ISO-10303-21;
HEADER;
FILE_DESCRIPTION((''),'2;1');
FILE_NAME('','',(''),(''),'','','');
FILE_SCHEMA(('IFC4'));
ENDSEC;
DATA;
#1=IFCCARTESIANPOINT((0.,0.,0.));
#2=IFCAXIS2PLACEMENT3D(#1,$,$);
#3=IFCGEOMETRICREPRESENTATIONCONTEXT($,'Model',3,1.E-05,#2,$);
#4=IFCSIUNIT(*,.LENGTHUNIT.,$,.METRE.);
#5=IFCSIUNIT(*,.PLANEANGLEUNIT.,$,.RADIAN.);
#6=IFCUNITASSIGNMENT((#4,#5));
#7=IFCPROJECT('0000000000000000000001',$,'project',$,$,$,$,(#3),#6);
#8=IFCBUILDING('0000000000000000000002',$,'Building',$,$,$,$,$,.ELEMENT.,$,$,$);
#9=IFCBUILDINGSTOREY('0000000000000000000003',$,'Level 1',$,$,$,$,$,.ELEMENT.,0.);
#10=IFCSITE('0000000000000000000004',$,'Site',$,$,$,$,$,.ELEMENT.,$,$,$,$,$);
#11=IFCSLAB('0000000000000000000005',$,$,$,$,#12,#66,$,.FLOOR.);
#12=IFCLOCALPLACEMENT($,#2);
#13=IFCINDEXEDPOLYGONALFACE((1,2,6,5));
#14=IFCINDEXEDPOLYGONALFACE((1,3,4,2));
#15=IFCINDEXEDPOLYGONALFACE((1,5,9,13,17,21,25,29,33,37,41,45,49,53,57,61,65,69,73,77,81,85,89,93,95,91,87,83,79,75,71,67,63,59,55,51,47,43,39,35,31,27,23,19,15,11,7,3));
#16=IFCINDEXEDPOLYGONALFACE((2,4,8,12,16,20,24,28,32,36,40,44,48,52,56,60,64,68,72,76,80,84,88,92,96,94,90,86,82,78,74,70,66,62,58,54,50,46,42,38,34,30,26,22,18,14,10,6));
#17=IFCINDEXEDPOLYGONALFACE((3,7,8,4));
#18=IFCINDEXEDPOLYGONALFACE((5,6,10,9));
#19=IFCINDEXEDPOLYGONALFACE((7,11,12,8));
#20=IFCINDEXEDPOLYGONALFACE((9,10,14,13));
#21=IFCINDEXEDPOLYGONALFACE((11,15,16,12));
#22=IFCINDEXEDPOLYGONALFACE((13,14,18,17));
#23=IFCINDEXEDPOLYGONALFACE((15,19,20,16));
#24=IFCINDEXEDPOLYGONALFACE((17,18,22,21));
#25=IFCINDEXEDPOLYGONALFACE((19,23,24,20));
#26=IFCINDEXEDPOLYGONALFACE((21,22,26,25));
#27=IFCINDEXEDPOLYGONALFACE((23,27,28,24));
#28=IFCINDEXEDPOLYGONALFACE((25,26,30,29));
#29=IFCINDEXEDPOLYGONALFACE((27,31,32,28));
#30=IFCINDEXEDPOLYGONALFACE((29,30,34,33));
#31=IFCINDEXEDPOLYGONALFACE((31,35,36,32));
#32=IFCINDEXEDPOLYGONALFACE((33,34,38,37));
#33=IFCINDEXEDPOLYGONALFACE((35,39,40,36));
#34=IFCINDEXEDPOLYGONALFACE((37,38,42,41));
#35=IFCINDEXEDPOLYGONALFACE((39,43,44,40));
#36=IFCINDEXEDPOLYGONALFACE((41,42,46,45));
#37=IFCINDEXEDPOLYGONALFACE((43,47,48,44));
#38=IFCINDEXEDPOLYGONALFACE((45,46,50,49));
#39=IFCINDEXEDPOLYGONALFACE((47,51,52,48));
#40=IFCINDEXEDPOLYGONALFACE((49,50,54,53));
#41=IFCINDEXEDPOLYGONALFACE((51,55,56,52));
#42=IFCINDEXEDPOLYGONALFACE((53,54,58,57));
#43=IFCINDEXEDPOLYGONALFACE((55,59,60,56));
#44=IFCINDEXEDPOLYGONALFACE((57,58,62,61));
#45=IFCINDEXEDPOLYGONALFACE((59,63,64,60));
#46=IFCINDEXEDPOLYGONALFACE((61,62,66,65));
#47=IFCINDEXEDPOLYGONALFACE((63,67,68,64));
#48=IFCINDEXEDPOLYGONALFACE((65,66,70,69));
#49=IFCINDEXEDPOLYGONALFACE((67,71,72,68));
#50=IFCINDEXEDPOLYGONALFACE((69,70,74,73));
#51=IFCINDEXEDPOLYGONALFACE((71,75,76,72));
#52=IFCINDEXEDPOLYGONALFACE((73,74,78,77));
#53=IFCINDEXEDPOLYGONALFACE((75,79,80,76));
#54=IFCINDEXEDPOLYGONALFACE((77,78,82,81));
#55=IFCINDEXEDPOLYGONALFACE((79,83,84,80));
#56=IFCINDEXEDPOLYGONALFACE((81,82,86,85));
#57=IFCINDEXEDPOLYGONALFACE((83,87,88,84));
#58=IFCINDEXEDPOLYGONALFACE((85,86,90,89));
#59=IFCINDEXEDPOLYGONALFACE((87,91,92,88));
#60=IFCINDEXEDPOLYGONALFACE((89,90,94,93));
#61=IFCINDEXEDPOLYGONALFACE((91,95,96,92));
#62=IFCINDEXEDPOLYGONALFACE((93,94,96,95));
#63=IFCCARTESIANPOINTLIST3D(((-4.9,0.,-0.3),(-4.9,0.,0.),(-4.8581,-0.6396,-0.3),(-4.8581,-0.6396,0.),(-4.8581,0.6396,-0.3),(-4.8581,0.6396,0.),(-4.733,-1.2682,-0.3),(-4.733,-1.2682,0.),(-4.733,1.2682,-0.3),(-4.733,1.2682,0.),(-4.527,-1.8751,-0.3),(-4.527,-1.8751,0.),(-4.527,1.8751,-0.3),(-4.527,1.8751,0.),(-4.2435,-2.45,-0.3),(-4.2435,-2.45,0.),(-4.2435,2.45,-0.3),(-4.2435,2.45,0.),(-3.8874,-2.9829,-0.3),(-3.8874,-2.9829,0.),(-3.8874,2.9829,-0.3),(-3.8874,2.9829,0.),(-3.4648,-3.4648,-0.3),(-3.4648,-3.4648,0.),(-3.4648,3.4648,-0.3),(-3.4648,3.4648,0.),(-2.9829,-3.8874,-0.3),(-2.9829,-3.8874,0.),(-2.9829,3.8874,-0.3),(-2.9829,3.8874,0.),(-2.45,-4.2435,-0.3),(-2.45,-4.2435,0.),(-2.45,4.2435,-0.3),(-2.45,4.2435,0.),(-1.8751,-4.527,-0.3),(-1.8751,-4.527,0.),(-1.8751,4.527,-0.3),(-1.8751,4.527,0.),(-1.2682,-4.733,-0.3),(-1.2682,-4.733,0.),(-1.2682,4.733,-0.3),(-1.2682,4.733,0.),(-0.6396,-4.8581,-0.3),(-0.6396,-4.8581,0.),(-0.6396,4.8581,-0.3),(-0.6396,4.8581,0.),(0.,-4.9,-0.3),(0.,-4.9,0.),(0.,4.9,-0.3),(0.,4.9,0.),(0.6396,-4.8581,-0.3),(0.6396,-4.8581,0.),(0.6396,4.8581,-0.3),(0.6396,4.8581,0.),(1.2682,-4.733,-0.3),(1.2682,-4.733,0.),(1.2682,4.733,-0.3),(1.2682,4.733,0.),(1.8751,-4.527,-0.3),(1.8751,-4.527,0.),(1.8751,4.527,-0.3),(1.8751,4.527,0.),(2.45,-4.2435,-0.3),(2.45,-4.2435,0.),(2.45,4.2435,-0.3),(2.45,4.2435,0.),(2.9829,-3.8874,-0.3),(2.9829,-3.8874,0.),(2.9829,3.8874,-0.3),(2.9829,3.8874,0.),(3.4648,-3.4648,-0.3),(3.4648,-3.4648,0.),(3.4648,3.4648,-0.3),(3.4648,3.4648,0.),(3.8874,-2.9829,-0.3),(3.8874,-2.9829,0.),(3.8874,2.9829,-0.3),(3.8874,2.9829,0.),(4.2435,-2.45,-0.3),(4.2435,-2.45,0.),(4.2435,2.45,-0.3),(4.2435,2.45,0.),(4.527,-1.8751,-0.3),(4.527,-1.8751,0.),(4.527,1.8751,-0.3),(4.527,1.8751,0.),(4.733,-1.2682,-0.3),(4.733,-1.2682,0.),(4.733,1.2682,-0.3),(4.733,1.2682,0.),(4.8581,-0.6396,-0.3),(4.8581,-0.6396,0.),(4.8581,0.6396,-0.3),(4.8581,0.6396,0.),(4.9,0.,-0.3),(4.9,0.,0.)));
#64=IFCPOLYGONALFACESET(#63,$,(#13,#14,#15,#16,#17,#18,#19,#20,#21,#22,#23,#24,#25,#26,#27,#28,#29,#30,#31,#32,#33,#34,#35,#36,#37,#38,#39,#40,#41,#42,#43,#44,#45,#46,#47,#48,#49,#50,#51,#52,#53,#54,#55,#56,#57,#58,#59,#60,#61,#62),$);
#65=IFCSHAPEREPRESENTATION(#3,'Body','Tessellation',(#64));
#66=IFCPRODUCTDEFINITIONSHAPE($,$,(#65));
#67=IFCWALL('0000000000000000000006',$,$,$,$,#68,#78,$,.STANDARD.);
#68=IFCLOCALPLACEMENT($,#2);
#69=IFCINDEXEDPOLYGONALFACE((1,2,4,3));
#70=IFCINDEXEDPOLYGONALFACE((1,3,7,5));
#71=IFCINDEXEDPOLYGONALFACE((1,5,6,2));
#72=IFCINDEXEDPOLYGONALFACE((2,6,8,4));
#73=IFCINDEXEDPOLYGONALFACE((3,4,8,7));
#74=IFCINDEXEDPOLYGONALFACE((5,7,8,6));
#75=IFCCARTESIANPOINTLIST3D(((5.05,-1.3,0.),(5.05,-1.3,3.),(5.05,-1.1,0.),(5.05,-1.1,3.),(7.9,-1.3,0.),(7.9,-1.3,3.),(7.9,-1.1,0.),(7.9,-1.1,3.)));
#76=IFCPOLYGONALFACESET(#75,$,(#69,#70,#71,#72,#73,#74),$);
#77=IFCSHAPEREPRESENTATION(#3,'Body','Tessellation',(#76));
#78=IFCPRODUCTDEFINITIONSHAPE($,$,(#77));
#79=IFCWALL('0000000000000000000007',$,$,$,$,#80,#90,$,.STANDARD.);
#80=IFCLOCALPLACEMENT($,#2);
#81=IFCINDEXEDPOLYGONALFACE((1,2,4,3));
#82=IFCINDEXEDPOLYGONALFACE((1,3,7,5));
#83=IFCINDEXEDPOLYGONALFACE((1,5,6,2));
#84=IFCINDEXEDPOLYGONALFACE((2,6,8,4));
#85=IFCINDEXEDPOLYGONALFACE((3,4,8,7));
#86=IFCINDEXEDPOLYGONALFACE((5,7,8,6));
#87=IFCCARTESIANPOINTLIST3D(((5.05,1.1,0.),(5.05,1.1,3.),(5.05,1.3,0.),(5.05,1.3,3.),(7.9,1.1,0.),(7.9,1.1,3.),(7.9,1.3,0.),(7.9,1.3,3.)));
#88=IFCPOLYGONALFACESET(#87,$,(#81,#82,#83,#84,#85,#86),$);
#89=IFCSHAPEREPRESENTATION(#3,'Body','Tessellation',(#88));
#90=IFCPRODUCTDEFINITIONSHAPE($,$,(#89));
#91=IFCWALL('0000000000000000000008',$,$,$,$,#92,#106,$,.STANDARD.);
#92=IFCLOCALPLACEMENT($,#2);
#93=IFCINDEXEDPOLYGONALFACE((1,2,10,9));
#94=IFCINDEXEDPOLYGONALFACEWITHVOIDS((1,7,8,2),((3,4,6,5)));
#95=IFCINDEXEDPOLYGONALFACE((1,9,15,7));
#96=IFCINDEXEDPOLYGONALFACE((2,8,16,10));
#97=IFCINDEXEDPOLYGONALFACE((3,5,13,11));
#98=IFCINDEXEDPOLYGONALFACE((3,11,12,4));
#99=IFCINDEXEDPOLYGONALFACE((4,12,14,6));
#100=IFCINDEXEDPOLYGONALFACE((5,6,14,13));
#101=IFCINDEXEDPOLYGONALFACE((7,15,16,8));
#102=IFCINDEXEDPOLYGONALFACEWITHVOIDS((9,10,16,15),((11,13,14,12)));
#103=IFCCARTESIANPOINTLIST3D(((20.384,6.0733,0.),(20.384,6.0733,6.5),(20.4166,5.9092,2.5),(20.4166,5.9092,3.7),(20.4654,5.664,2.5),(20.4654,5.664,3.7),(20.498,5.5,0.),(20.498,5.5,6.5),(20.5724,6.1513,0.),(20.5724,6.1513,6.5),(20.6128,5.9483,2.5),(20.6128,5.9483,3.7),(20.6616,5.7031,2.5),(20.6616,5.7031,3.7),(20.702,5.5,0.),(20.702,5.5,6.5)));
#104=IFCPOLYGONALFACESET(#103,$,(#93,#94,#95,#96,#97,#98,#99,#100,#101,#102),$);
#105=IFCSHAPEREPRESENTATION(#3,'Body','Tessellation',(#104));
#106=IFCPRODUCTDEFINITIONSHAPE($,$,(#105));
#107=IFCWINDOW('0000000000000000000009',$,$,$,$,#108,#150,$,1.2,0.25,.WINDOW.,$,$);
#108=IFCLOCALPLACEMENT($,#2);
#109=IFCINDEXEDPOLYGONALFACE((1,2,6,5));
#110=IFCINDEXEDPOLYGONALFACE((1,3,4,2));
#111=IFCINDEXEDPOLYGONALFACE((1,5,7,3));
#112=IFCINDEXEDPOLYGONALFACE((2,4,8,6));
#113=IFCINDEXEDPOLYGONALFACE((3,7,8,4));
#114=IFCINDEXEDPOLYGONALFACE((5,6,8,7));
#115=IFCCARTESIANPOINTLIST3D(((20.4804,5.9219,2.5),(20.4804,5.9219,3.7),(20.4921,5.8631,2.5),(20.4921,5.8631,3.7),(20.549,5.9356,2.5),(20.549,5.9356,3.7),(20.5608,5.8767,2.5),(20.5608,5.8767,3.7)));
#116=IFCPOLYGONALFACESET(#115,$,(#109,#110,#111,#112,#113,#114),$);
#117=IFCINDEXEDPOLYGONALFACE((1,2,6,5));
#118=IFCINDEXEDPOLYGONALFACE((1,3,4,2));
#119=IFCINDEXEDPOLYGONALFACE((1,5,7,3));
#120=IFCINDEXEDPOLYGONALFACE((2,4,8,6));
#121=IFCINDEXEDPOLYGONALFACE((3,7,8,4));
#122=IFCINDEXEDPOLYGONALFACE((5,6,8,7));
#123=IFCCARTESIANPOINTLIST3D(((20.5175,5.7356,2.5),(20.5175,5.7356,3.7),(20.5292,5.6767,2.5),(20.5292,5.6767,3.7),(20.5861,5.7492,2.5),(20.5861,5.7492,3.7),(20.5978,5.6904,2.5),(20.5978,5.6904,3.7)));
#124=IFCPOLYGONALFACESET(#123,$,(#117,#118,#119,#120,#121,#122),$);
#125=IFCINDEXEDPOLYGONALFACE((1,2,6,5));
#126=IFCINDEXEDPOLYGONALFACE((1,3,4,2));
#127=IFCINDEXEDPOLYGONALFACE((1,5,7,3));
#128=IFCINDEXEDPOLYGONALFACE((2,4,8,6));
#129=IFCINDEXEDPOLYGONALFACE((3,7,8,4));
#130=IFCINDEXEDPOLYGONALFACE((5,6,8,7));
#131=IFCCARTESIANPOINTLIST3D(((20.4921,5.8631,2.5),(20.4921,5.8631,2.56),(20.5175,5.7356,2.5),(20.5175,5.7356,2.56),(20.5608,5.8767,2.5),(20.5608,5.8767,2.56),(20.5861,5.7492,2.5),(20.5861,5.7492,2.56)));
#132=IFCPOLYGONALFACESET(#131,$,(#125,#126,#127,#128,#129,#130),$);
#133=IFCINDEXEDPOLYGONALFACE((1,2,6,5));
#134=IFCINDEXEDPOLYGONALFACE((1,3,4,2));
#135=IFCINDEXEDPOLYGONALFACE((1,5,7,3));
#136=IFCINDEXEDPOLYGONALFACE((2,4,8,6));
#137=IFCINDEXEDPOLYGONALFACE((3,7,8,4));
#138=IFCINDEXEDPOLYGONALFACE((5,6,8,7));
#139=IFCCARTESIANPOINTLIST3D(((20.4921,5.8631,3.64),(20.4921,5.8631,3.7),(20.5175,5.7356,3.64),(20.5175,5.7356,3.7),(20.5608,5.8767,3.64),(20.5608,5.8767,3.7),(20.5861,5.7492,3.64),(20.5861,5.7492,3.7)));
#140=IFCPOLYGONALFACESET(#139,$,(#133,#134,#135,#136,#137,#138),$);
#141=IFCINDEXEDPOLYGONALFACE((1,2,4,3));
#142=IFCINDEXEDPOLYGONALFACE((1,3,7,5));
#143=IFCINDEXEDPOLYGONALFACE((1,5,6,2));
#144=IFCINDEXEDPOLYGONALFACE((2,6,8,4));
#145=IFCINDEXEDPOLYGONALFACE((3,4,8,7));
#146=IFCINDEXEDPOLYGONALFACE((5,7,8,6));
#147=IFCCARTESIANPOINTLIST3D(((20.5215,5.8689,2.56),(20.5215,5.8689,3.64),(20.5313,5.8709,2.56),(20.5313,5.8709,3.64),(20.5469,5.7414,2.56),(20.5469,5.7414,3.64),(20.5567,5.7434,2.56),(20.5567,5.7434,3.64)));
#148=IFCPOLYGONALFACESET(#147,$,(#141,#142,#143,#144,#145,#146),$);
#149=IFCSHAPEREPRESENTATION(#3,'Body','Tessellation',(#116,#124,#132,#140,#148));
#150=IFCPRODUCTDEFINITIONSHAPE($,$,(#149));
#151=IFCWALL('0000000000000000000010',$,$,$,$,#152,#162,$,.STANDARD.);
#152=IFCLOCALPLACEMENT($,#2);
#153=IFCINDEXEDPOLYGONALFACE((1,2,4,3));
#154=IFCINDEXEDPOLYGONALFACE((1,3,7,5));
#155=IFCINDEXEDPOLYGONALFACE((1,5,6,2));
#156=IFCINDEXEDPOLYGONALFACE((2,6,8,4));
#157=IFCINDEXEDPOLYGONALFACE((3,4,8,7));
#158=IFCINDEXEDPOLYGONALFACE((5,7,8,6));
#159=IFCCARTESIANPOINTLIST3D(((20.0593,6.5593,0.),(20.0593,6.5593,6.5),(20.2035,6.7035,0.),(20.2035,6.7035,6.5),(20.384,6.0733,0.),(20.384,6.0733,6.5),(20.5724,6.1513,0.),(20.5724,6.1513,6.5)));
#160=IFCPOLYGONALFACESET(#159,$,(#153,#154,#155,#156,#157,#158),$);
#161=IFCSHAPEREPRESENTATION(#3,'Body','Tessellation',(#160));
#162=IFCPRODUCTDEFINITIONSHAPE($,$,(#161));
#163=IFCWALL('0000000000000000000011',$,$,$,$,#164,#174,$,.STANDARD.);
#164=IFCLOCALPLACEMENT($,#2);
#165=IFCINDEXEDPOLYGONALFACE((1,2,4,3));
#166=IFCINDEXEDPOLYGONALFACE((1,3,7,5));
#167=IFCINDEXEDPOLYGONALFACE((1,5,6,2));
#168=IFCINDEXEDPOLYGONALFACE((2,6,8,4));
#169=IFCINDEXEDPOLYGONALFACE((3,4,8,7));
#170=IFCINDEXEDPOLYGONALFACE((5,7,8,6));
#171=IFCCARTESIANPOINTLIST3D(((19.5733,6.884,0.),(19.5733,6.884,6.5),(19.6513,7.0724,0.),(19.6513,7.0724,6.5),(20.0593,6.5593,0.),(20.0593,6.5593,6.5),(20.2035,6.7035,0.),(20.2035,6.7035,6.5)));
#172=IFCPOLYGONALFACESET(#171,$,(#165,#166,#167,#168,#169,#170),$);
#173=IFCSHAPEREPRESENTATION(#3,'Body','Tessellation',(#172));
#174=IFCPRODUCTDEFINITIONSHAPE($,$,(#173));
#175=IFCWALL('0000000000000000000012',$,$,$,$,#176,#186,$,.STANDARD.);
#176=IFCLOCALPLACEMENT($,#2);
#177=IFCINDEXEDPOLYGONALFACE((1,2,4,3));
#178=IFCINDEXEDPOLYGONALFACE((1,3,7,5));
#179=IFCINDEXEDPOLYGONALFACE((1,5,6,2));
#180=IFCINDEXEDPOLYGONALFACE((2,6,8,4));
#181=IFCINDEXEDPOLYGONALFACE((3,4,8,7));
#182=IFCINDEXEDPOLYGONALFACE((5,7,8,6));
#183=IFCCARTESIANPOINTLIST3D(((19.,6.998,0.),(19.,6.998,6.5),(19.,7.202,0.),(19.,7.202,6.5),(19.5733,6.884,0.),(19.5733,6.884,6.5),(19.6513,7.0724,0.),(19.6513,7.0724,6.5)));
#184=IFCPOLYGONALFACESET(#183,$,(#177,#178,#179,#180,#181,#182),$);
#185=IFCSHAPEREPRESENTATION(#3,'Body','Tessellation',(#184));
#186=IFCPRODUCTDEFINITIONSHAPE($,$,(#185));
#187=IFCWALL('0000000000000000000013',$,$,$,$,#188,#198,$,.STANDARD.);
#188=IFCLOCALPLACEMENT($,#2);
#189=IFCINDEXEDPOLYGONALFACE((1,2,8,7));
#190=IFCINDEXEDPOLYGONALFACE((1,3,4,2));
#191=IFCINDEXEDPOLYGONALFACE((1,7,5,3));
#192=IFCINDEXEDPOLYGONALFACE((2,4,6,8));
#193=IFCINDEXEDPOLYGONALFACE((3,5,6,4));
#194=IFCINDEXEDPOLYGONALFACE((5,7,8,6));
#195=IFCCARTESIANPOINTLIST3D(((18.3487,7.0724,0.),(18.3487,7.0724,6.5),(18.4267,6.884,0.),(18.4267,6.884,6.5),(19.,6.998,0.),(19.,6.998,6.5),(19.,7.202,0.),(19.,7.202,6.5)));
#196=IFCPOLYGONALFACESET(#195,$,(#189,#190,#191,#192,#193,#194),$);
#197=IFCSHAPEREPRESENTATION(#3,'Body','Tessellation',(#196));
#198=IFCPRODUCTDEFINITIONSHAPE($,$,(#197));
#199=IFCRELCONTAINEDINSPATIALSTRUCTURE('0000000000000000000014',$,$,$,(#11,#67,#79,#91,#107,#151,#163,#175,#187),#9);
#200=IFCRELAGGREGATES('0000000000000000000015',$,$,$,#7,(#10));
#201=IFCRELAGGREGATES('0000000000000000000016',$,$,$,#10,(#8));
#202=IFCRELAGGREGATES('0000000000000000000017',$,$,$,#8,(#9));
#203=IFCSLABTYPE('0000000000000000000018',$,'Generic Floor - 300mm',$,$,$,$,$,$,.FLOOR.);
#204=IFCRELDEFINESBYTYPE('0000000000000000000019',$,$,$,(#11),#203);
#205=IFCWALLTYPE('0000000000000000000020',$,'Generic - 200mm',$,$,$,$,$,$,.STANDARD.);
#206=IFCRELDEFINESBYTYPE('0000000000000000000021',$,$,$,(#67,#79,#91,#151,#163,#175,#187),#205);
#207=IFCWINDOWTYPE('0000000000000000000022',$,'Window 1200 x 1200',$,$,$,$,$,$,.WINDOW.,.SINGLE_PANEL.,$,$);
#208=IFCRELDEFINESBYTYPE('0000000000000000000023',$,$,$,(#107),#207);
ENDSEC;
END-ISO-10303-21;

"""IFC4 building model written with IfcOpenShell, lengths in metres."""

from ifc_helpers import new_model, si_unit, frame, frame_2d, origin, origin_with_axes, origin_2d, place, context, project, spatial, polyline, rectangle, outline, extrude, type_object, element, fill, save


model = new_model("IFC4")

# Units and contexts
model_context = context("Model", 3, precision=1e-05, world=origin())
ifc_project = project(units=[si_unit("LENGTHUNIT", "METRE"), si_unit("PLANEANGLEUNIT", "RADIAN")], contexts=[model_context])

# Site, building, storey
site = spatial("IfcSite", under=ifc_project, Name="Site", CompositionType="ELEMENT")
building = spatial("IfcBuilding", under=site, Name="Building", CompositionType="ELEMENT")
storey = spatial("IfcBuildingStorey", under=building, Name="Level 1", CompositionType="ELEMENT", Elevation=0.0)

# Slab
slab_type = type_object("IfcSlabType", Name="Generic Floor - 300mm", PredefinedType="FLOOR")
slab_placement = place(None, origin())
element("IfcSlab", 1, at=slab_placement, inside=storey, type_object=slab_type, PredefinedType="FLOOR", context=model_context, shape_type="SweptSolid", body=[
    extrude(outline(polyline([(4.9, 0.0), (4.8581, 0.6396), (4.733, 1.2682), (4.527, 1.8751), (4.2435, 2.45), (3.8874, 2.9829), (3.4648, 3.4648), (2.9829, 3.8874), (2.45, 4.2435), (1.8751, 4.527), (1.2682, 4.733), (0.6396, 4.8581), (0.0, 4.9), (-0.6396, 4.8581), (-1.2682, 4.733), (-1.8751, 4.527), (-2.45, 4.2435), (-2.9829, 3.8874), (-3.4648, 3.4648), (-3.8874, 2.9829), (-4.2435, 2.45), (-4.527, 1.8751), (-4.733, 1.2682), (-4.8581, 0.6396), (-4.9, 0.0), (-4.8581, -0.6396), (-4.733, -1.2682), (-4.527, -1.8751), (-4.2435, -2.45), (-3.8874, -2.9829), (-3.4648, -3.4648), (-2.9829, -3.8874), (-2.45, -4.2435), (-1.8751, -4.527), (-1.2682, -4.733), (-0.6396, -4.8581), (0.0, -4.9), (0.6396, -4.8581), (1.2682, -4.733), (1.8751, -4.527), (2.45, -4.2435), (2.9829, -3.8874), (3.4648, -3.4648), (3.8874, -2.9829), (4.2435, -2.45), (4.527, -1.8751), (4.733, -1.2682), (4.8581, -0.6396), (4.9, 0.0)])), origin(), (0.0, 0.0, -1.0), 0.3),
])

# Walls
wall_type_1 = type_object("IfcWallType", Name="Generic - 200mm", PredefinedType="STANDARD")
wall_1_placement = place(None, frame((5.05, -1.2, 0.0), z_axis=(0.0, 0.0, 1.0), x_axis=(1.0, 0.0, 0.0)))
element("IfcWall", 2, at=wall_1_placement, inside=storey, type_object=wall_type_1, PredefinedType="STANDARD", context=model_context, shape_type="SweptSolid", body=[
    extrude(outline(polyline([(0.0, -0.1), (2.85, -0.1), (2.85, 0.1), (0.0, 0.1), (0.0, -0.1)])), origin(), (0.0, 0.0, 1.0), 3.0),
])
wall_2_placement = place(None, frame((8.0, 1.2, 0.0), z_axis=(0.0, 0.0, 1.0), x_axis=(-1.0, 0.0, 0.0)))
element("IfcWall", 3, at=wall_2_placement, inside=storey, type_object=wall_type_1, PredefinedType="STANDARD", context=model_context, shape_type="SweptSolid", body=[
    extrude(outline(polyline([(0.1, -0.1), (2.95, -0.1), (2.95, 0.1), (0.1, 0.1), (0.1, -0.1)])), origin(), (0.0, 0.0, 1.0), 3.0),
])

# Wall, opening, window
wall_3_placement = place(None, frame((20.4782, 6.1123, 0.0), z_axis=(0.0, 0.0, 1.0), x_axis=(0.19509, -0.980785, 0.0)))
wall_3 = element("IfcWall", 4, at=wall_3_placement, inside=storey, type_object=wall_type_1, PredefinedType="STANDARD", context=model_context, shape_type="SweptSolid", body=[
    extrude(outline(polyline([(0.0199, -0.1), (0.6044, -0.1), (0.6442, 0.1), (-0.0199, 0.1), (0.0199, -0.1)])), origin(), (0.0, 0.0, 1.0), 6.5),
])
opening_1_placement = place(wall_3_placement, frame((0.3121, 0.0, 2.5), z_axis=(0.0, 0.0, 1.0), x_axis=(1.0, 0.0, 0.0)))
opening_1 = element("IfcOpeningElement", 5, at=opening_1_placement, cuts=wall_3, PredefinedType="OPENING", context=model_context, shape_type="SweptSolid", body=[
    extrude(rectangle(XDim=0.25, YDim=0.202, at=origin_2d()), origin(), (0.0, 0.0, 1.0), 1.2),
])
window_type = type_object("IfcWindowType", Name="Window 1200 x 1200", PartitioningType="SINGLE_PANEL", PredefinedType="WINDOW")
window_1_placement = place(opening_1_placement, origin_with_axes())
window_1 = element("IfcWindow", 6, at=window_1_placement, inside=storey, type_object=window_type, OverallHeight=1.2, OverallWidth=0.25, PredefinedType="WINDOW", context=model_context, shape_type="SweptSolid", body=[
    extrude(rectangle(XDim=0.06, YDim=0.07, at=frame_2d((-0.095, 0.0))), origin(), (0.0, 0.0, 1.0), 1.2),
    extrude(rectangle(XDim=0.06, YDim=0.07, at=frame_2d((0.095, 0.0))), origin(), (0.0, 0.0, 1.0), 1.2),
    extrude(rectangle(XDim=0.13, YDim=0.07, at=origin_2d()), origin(), (0.0, 0.0, 1.0), 0.06),
    extrude(rectangle(XDim=0.13, YDim=0.07, at=origin_2d()), frame((0.0, 0.0, 1.14)), (0.0, 0.0, 1.0), 0.06),
    extrude(rectangle(XDim=0.13, YDim=0.01, at=origin_2d()), frame((0.0, 0.0, 0.06)), (0.0, 0.0, 1.0), 1.08),
])
fill(opening_1, window_1)

# Walls
wall_4_placement = place(None, frame((20.1314, 6.6314, 0.0), z_axis=(0.0, 0.0, 1.0), x_axis=(0.55557, -0.83147, 0.0)))
element("IfcWall", 7, at=wall_4_placement, inside=storey, type_object=wall_type_1, PredefinedType="STANDARD", context=model_context, shape_type="SweptSolid", body=[
    extrude(outline(polyline([(0.0199, -0.1), (0.6044, -0.1), (0.6442, 0.1), (-0.0199, 0.1), (0.0199, -0.1)])), origin(), (0.0, 0.0, 1.0), 6.5),
])
wall_5_placement = place(None, frame((19.6123, 6.9782, 0.0), z_axis=(0.0, 0.0, 1.0), x_axis=(0.83147, -0.55557, 0.0)))
element("IfcWall", 8, at=wall_5_placement, inside=storey, type_object=wall_type_1, PredefinedType="STANDARD", context=model_context, shape_type="SweptSolid", body=[
    extrude(outline(polyline([(0.0199, -0.1), (0.6044, -0.1), (0.6442, 0.1), (-0.0199, 0.1), (0.0199, -0.1)])), origin(), (0.0, 0.0, 1.0), 6.5),
])
wall_6_placement = place(None, frame((19.0, 7.1, 0.0), z_axis=(0.0, 0.0, 1.0), x_axis=(0.980785, -0.19509, 0.0)))
element("IfcWall", 9, at=wall_6_placement, inside=storey, type_object=wall_type_1, PredefinedType="STANDARD", context=model_context, shape_type="SweptSolid", body=[
    extrude(outline(polyline([(0.0199, -0.1), (0.6044, -0.1), (0.6442, 0.1), (-0.0199, 0.1), (0.0199, -0.1)])), origin(), (0.0, 0.0, 1.0), 6.5),
])
wall_7_placement = place(None, frame((18.3877, 6.9782, 0.0), z_axis=(0.0, 0.0, 1.0), x_axis=(0.980785, 0.19509, 0.0)))
element("IfcWall", 10, at=wall_7_placement, inside=storey, type_object=wall_type_1, PredefinedType="STANDARD", context=model_context, shape_type="SweptSolid", body=[
    extrude(outline(polyline([(0.0199, -0.1), (0.6044, -0.1), (0.6442, 0.1), (-0.0199, 0.1), (0.0199, -0.1)])), origin(), (0.0, 0.0, 1.0), 6.5),
])

save(model, "model.ifc")
